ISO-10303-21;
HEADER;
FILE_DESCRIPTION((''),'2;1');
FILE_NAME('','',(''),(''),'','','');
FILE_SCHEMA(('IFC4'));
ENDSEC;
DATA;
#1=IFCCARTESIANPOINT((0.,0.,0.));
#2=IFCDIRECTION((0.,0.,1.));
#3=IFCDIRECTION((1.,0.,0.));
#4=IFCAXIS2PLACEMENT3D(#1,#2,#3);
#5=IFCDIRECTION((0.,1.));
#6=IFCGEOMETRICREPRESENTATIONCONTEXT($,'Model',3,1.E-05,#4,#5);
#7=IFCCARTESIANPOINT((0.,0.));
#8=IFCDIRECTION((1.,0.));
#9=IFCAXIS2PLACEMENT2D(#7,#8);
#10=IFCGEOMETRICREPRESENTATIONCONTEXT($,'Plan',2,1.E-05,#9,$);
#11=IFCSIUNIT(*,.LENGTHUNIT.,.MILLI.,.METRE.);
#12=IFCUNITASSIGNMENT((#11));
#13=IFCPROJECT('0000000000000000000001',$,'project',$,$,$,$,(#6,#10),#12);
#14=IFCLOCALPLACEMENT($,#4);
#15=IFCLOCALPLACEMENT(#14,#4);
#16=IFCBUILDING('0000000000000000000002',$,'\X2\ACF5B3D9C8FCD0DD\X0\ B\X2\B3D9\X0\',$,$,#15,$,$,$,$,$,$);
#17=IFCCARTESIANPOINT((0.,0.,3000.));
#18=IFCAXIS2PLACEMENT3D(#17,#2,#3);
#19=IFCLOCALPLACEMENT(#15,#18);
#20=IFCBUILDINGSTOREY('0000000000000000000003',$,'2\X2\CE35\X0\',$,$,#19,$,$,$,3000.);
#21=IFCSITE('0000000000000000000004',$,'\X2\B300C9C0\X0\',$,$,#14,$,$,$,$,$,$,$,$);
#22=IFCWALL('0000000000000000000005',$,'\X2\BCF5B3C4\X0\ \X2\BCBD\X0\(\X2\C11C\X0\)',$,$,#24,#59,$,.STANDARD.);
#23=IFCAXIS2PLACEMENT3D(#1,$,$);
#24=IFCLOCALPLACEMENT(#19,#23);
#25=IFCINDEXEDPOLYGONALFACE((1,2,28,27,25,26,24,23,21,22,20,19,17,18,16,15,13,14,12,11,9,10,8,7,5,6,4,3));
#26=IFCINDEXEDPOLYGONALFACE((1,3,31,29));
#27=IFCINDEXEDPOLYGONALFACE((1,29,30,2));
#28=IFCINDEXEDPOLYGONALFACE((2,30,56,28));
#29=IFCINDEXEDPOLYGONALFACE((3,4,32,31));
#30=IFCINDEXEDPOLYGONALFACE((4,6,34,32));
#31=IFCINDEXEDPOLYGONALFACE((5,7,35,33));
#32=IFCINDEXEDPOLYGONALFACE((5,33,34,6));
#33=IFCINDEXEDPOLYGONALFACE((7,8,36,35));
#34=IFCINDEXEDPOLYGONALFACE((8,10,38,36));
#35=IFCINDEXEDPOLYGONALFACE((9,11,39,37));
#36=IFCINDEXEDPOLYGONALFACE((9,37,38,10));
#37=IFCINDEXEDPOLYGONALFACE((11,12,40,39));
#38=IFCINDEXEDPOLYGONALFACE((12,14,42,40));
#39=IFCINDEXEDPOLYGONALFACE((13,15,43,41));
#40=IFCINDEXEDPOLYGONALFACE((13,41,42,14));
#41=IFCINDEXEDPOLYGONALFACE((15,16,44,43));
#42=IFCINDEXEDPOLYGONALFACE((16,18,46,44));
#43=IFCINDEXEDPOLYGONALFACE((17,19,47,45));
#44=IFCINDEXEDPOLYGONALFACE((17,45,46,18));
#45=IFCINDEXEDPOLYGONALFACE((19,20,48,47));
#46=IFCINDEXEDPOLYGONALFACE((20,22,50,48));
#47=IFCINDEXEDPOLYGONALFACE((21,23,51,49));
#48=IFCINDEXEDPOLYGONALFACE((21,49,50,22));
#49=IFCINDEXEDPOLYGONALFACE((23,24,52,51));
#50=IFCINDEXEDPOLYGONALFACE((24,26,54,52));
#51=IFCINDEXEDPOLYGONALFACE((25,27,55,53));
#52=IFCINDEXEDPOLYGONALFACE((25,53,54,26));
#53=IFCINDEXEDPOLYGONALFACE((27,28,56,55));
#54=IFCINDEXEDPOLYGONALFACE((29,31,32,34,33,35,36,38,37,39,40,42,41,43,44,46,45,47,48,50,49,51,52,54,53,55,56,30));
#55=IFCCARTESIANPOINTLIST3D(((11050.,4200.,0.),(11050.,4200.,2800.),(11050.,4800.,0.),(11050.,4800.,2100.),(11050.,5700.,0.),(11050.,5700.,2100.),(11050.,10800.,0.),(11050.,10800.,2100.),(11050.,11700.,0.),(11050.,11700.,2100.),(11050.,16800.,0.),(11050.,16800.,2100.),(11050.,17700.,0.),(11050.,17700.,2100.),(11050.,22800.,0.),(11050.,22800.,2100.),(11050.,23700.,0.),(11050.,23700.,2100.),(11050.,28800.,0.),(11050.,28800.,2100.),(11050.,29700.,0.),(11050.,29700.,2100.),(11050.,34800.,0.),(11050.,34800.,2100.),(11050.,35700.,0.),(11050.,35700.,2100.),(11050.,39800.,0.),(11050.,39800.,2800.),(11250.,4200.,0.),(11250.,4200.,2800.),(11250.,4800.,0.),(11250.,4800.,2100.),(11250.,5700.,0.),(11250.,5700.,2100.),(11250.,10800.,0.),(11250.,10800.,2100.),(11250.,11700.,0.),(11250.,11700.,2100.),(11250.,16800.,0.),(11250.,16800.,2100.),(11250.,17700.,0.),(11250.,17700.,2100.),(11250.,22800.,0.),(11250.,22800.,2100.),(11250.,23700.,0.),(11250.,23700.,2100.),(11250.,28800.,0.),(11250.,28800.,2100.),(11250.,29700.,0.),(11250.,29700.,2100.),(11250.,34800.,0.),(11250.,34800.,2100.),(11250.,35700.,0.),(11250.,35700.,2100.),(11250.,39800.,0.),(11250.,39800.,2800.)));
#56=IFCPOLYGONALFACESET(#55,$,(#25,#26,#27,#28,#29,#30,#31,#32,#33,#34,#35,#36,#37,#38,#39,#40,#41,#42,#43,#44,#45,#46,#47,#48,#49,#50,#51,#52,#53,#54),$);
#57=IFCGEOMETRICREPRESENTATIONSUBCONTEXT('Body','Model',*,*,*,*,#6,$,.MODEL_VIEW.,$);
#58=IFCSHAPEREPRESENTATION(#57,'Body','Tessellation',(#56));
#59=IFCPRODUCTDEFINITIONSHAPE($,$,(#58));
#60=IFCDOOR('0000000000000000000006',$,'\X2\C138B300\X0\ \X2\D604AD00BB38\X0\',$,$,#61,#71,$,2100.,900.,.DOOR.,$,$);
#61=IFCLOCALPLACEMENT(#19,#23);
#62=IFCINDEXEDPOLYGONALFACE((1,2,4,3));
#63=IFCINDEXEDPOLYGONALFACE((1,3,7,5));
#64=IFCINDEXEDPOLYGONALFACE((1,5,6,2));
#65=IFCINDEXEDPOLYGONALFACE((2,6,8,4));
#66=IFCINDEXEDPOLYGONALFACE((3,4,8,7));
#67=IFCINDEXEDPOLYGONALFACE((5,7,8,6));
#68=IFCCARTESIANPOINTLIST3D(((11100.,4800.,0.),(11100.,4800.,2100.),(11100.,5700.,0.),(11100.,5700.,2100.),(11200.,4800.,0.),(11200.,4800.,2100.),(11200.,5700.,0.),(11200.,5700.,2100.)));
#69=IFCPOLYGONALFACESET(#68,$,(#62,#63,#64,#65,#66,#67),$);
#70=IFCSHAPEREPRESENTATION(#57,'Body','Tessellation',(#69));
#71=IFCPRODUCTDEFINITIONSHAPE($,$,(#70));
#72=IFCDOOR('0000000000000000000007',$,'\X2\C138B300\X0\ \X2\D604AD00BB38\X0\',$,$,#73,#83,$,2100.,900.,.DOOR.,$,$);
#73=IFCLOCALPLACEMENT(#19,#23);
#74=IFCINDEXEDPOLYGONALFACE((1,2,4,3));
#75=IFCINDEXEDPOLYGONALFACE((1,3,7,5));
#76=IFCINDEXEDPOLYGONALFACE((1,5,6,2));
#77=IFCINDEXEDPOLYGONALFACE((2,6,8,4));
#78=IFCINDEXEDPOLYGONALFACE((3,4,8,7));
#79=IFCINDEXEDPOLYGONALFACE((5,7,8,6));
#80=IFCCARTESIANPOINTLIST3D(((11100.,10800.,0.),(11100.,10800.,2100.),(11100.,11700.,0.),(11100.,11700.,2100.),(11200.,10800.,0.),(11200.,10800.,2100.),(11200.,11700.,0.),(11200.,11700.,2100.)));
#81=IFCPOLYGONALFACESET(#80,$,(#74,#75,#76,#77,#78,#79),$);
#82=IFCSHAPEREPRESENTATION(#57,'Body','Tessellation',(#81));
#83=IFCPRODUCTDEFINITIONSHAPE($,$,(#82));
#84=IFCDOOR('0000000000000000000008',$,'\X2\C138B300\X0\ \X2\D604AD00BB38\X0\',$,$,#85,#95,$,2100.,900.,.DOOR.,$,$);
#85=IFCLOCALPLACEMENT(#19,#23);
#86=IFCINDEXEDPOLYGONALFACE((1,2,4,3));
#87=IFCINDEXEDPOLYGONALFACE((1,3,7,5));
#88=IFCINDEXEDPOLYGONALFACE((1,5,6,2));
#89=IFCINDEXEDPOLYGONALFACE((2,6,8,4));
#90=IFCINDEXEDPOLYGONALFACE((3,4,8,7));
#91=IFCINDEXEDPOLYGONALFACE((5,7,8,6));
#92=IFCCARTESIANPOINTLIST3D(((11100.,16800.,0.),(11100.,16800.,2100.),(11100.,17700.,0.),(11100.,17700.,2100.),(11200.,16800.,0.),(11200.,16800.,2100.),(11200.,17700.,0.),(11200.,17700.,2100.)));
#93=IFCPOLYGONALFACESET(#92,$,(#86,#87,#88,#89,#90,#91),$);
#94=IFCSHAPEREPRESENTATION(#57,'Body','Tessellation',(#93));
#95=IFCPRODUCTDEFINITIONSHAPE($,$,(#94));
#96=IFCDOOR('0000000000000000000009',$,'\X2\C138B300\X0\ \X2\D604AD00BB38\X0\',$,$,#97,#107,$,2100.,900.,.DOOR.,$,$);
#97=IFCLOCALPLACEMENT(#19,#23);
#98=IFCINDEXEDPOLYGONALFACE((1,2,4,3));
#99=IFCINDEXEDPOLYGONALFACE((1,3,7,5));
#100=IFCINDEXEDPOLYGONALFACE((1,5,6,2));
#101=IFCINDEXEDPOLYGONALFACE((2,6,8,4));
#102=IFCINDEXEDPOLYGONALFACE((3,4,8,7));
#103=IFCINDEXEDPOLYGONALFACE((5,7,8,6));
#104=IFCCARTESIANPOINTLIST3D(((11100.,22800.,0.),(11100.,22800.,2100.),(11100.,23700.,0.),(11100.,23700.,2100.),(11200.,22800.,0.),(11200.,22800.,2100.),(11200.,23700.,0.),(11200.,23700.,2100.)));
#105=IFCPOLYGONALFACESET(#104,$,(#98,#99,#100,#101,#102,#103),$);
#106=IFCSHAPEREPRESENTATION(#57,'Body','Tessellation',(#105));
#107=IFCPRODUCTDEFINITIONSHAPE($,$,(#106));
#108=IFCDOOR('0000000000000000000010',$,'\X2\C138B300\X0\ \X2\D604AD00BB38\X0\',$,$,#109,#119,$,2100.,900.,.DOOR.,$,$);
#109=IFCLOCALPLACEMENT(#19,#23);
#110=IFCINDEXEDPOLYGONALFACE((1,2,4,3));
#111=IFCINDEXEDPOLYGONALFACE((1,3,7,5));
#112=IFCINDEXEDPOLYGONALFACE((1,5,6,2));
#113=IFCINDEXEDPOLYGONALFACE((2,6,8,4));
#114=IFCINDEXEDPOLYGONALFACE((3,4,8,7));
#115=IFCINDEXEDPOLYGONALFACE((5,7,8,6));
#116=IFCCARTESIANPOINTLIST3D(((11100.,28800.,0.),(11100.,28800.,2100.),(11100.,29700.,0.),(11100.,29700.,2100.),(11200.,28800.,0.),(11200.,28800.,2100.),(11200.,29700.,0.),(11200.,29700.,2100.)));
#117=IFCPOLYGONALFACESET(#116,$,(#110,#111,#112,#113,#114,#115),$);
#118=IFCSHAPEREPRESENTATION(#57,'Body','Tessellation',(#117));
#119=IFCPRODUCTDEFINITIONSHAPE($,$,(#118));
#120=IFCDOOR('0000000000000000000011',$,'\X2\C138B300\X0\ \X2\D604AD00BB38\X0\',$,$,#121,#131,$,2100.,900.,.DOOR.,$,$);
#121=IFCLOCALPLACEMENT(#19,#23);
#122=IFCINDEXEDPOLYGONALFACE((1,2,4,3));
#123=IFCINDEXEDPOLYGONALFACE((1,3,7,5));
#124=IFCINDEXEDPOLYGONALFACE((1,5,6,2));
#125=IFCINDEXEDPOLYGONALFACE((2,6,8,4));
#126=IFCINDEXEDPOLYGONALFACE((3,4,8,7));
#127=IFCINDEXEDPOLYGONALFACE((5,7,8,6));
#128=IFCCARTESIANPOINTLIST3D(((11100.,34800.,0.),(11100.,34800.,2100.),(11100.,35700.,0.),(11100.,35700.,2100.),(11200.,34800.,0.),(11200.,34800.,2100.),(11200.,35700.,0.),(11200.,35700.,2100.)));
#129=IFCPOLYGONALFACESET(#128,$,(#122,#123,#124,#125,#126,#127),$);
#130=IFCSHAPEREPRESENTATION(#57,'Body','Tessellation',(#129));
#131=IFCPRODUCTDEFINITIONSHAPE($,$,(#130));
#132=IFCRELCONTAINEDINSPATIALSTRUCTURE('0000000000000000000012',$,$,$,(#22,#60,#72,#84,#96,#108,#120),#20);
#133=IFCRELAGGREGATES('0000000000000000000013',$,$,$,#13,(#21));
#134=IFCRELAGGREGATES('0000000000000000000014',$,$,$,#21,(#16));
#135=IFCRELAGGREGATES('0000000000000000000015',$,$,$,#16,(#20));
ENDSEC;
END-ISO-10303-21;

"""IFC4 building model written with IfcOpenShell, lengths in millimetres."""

from ifc_helpers import new_model, si_unit, direction, frame, origin_with_axes, origin_2d_with_axis, place, context, subcontext, project, spatial, polyline, outline, extrude, element, fill, save


model = new_model("IFC4")

# Units and contexts
model_context = context("Model", 3, precision=1e-05, world=origin_with_axes(), true_north=direction((0.0, 1.0)))
plan_context = context("Plan", 2, precision=1e-05, world=origin_2d_with_axis())
body_context = subcontext(model_context, "Body", "Model", "MODEL_VIEW")
ifc_project = project(units=[si_unit("LENGTHUNIT", "METRE", prefix="MILLI")], contexts=[model_context, plan_context])

# Site, building, storey
site_placement = place(None, origin_with_axes())
site = spatial("IfcSite", under=ifc_project, at=site_placement, Name="대지")
building_placement = place(site_placement, origin_with_axes())
building = spatial("IfcBuilding", under=site, at=building_placement, Name="공동주택 B동")
storey_placement = place(building_placement, frame((0.0, 0.0, 3000.0), z_axis=(0.0, 0.0, 1.0), x_axis=(1.0, 0.0, 0.0)))
storey = spatial("IfcBuildingStorey", under=building, at=storey_placement, Name="2층", Elevation=3000.0)

# Wall, openings, doors
wall_1_placement = place(storey_placement, origin_with_axes())
wall_1 = element("IfcWall", 1, at=wall_1_placement, inside=storey, Name="복도 벽(서)", PredefinedType="STANDARD", context=body_context, shape_type="SweptSolid", body=[
    extrude(outline(polyline([(11050.0, 4200.0), (11050.0, 39800.0), (11250.0, 39800.0), (11250.0, 4200.0), (11050.0, 4200.0)])), origin_with_axes(), (0.0, 0.0, 1.0), 2800.0),
])
opening_1_placement = place(storey_placement, origin_with_axes())
opening_1 = element("IfcOpeningElement", 2, at=opening_1_placement, cuts=wall_1, PredefinedType="OPENING", context=body_context, shape_type="SweptSolid", body=[
    extrude(outline(polyline([(11300.0, 4800.0), (11300.0, 5700.0), (11000.0, 5700.0), (11000.0, 4800.0), (11300.0, 4800.0)])), origin_with_axes(), (0.0, 0.0, 1.0), 2100.0),
])
opening_2_placement = place(storey_placement, origin_with_axes())
opening_2 = element("IfcOpeningElement", 3, at=opening_2_placement, cuts=wall_1, PredefinedType="OPENING", context=body_context, shape_type="SweptSolid", body=[
    extrude(outline(polyline([(11300.0, 10800.0), (11300.0, 11700.0), (11000.0, 11700.0), (11000.0, 10800.0), (11300.0, 10800.0)])), origin_with_axes(), (0.0, 0.0, 1.0), 2100.0),
])
opening_3_placement = place(storey_placement, origin_with_axes())
opening_3 = element("IfcOpeningElement", 4, at=opening_3_placement, cuts=wall_1, PredefinedType="OPENING", context=body_context, shape_type="SweptSolid", body=[
    extrude(outline(polyline([(11300.0, 16800.0), (11300.0, 17700.0), (11000.0, 17700.0), (11000.0, 16800.0), (11300.0, 16800.0)])), origin_with_axes(), (0.0, 0.0, 1.0), 2100.0),
])
opening_4_placement = place(storey_placement, origin_with_axes())
opening_4 = element("IfcOpeningElement", 5, at=opening_4_placement, cuts=wall_1, PredefinedType="OPENING", context=body_context, shape_type="SweptSolid", body=[
    extrude(outline(polyline([(11300.0, 22800.0), (11300.0, 23700.0), (11000.0, 23700.0), (11000.0, 22800.0), (11300.0, 22800.0)])), origin_with_axes(), (0.0, 0.0, 1.0), 2100.0),
])
opening_5_placement = place(storey_placement, origin_with_axes())
opening_5 = element("IfcOpeningElement", 6, at=opening_5_placement, cuts=wall_1, PredefinedType="OPENING", context=body_context, shape_type="SweptSolid", body=[
    extrude(outline(polyline([(11300.0, 28800.0), (11300.0, 29700.0), (11000.0, 29700.0), (11000.0, 28800.0), (11300.0, 28800.0)])), origin_with_axes(), (0.0, 0.0, 1.0), 2100.0),
])
opening_6_placement = place(storey_placement, origin_with_axes())
opening_6 = element("IfcOpeningElement", 7, at=opening_6_placement, cuts=wall_1, PredefinedType="OPENING", context=body_context, shape_type="SweptSolid", body=[
    extrude(outline(polyline([(11300.0, 34800.0), (11300.0, 35700.0), (11000.0, 35700.0), (11000.0, 34800.0), (11300.0, 34800.0)])), origin_with_axes(), (0.0, 0.0, 1.0), 2100.0),
])
door_1_placement = place(storey_placement, origin_with_axes())
door_1 = element("IfcDoor", 8, at=door_1_placement, inside=storey, Name="세대 현관문", OverallHeight=2100.0, OverallWidth=900.0, PredefinedType="DOOR", context=body_context, shape_type="SweptSolid", body=[
    extrude(outline(polyline([(11200.0, 4800.0), (11200.0, 5700.0), (11100.0, 5700.0), (11100.0, 4800.0), (11200.0, 4800.0)])), origin_with_axes(), (0.0, 0.0, 1.0), 2100.0),
])
fill(opening_1, door_1)
door_2_placement = place(storey_placement, origin_with_axes())
door_2 = element("IfcDoor", 9, at=door_2_placement, inside=storey, Name="세대 현관문", OverallHeight=2100.0, OverallWidth=900.0, PredefinedType="DOOR", context=body_context, shape_type="SweptSolid", body=[
    extrude(outline(polyline([(11200.0, 10800.0), (11200.0, 11700.0), (11100.0, 11700.0), (11100.0, 10800.0), (11200.0, 10800.0)])), origin_with_axes(), (0.0, 0.0, 1.0), 2100.0),
])
fill(opening_2, door_2)
door_3_placement = place(storey_placement, origin_with_axes())
door_3 = element("IfcDoor", 10, at=door_3_placement, inside=storey, Name="세대 현관문", OverallHeight=2100.0, OverallWidth=900.0, PredefinedType="DOOR", context=body_context, shape_type="SweptSolid", body=[
    extrude(outline(polyline([(11200.0, 16800.0), (11200.0, 17700.0), (11100.0, 17700.0), (11100.0, 16800.0), (11200.0, 16800.0)])), origin_with_axes(), (0.0, 0.0, 1.0), 2100.0),
])
fill(opening_3, door_3)
door_4_placement = place(storey_placement, origin_with_axes())
door_4 = element("IfcDoor", 11, at=door_4_placement, inside=storey, Name="세대 현관문", OverallHeight=2100.0, OverallWidth=900.0, PredefinedType="DOOR", context=body_context, shape_type="SweptSolid", body=[
    extrude(outline(polyline([(11200.0, 22800.0), (11200.0, 23700.0), (11100.0, 23700.0), (11100.0, 22800.0), (11200.0, 22800.0)])), origin_with_axes(), (0.0, 0.0, 1.0), 2100.0),
])
fill(opening_4, door_4)
door_5_placement = place(storey_placement, origin_with_axes())
door_5 = element("IfcDoor", 12, at=door_5_placement, inside=storey, Name="세대 현관문", OverallHeight=2100.0, OverallWidth=900.0, PredefinedType="DOOR", context=body_context, shape_type="SweptSolid", body=[
    extrude(outline(polyline([(11200.0, 28800.0), (11200.0, 29700.0), (11100.0, 29700.0), (11100.0, 28800.0), (11200.0, 28800.0)])), origin_with_axes(), (0.0, 0.0, 1.0), 2100.0),
])
fill(opening_5, door_5)
door_6_placement = place(storey_placement, origin_with_axes())
door_6 = element("IfcDoor", 13, at=door_6_placement, inside=storey, Name="세대 현관문", OverallHeight=2100.0, OverallWidth=900.0, PredefinedType="DOOR", context=body_context, shape_type="SweptSolid", body=[
    extrude(outline(polyline([(11200.0, 34800.0), (11200.0, 35700.0), (11100.0, 35700.0), (11100.0, 34800.0), (11200.0, 34800.0)])), origin_with_axes(), (0.0, 0.0, 1.0), 2100.0),
])
fill(opening_6, door_6)

save(model, "model.ifc")
